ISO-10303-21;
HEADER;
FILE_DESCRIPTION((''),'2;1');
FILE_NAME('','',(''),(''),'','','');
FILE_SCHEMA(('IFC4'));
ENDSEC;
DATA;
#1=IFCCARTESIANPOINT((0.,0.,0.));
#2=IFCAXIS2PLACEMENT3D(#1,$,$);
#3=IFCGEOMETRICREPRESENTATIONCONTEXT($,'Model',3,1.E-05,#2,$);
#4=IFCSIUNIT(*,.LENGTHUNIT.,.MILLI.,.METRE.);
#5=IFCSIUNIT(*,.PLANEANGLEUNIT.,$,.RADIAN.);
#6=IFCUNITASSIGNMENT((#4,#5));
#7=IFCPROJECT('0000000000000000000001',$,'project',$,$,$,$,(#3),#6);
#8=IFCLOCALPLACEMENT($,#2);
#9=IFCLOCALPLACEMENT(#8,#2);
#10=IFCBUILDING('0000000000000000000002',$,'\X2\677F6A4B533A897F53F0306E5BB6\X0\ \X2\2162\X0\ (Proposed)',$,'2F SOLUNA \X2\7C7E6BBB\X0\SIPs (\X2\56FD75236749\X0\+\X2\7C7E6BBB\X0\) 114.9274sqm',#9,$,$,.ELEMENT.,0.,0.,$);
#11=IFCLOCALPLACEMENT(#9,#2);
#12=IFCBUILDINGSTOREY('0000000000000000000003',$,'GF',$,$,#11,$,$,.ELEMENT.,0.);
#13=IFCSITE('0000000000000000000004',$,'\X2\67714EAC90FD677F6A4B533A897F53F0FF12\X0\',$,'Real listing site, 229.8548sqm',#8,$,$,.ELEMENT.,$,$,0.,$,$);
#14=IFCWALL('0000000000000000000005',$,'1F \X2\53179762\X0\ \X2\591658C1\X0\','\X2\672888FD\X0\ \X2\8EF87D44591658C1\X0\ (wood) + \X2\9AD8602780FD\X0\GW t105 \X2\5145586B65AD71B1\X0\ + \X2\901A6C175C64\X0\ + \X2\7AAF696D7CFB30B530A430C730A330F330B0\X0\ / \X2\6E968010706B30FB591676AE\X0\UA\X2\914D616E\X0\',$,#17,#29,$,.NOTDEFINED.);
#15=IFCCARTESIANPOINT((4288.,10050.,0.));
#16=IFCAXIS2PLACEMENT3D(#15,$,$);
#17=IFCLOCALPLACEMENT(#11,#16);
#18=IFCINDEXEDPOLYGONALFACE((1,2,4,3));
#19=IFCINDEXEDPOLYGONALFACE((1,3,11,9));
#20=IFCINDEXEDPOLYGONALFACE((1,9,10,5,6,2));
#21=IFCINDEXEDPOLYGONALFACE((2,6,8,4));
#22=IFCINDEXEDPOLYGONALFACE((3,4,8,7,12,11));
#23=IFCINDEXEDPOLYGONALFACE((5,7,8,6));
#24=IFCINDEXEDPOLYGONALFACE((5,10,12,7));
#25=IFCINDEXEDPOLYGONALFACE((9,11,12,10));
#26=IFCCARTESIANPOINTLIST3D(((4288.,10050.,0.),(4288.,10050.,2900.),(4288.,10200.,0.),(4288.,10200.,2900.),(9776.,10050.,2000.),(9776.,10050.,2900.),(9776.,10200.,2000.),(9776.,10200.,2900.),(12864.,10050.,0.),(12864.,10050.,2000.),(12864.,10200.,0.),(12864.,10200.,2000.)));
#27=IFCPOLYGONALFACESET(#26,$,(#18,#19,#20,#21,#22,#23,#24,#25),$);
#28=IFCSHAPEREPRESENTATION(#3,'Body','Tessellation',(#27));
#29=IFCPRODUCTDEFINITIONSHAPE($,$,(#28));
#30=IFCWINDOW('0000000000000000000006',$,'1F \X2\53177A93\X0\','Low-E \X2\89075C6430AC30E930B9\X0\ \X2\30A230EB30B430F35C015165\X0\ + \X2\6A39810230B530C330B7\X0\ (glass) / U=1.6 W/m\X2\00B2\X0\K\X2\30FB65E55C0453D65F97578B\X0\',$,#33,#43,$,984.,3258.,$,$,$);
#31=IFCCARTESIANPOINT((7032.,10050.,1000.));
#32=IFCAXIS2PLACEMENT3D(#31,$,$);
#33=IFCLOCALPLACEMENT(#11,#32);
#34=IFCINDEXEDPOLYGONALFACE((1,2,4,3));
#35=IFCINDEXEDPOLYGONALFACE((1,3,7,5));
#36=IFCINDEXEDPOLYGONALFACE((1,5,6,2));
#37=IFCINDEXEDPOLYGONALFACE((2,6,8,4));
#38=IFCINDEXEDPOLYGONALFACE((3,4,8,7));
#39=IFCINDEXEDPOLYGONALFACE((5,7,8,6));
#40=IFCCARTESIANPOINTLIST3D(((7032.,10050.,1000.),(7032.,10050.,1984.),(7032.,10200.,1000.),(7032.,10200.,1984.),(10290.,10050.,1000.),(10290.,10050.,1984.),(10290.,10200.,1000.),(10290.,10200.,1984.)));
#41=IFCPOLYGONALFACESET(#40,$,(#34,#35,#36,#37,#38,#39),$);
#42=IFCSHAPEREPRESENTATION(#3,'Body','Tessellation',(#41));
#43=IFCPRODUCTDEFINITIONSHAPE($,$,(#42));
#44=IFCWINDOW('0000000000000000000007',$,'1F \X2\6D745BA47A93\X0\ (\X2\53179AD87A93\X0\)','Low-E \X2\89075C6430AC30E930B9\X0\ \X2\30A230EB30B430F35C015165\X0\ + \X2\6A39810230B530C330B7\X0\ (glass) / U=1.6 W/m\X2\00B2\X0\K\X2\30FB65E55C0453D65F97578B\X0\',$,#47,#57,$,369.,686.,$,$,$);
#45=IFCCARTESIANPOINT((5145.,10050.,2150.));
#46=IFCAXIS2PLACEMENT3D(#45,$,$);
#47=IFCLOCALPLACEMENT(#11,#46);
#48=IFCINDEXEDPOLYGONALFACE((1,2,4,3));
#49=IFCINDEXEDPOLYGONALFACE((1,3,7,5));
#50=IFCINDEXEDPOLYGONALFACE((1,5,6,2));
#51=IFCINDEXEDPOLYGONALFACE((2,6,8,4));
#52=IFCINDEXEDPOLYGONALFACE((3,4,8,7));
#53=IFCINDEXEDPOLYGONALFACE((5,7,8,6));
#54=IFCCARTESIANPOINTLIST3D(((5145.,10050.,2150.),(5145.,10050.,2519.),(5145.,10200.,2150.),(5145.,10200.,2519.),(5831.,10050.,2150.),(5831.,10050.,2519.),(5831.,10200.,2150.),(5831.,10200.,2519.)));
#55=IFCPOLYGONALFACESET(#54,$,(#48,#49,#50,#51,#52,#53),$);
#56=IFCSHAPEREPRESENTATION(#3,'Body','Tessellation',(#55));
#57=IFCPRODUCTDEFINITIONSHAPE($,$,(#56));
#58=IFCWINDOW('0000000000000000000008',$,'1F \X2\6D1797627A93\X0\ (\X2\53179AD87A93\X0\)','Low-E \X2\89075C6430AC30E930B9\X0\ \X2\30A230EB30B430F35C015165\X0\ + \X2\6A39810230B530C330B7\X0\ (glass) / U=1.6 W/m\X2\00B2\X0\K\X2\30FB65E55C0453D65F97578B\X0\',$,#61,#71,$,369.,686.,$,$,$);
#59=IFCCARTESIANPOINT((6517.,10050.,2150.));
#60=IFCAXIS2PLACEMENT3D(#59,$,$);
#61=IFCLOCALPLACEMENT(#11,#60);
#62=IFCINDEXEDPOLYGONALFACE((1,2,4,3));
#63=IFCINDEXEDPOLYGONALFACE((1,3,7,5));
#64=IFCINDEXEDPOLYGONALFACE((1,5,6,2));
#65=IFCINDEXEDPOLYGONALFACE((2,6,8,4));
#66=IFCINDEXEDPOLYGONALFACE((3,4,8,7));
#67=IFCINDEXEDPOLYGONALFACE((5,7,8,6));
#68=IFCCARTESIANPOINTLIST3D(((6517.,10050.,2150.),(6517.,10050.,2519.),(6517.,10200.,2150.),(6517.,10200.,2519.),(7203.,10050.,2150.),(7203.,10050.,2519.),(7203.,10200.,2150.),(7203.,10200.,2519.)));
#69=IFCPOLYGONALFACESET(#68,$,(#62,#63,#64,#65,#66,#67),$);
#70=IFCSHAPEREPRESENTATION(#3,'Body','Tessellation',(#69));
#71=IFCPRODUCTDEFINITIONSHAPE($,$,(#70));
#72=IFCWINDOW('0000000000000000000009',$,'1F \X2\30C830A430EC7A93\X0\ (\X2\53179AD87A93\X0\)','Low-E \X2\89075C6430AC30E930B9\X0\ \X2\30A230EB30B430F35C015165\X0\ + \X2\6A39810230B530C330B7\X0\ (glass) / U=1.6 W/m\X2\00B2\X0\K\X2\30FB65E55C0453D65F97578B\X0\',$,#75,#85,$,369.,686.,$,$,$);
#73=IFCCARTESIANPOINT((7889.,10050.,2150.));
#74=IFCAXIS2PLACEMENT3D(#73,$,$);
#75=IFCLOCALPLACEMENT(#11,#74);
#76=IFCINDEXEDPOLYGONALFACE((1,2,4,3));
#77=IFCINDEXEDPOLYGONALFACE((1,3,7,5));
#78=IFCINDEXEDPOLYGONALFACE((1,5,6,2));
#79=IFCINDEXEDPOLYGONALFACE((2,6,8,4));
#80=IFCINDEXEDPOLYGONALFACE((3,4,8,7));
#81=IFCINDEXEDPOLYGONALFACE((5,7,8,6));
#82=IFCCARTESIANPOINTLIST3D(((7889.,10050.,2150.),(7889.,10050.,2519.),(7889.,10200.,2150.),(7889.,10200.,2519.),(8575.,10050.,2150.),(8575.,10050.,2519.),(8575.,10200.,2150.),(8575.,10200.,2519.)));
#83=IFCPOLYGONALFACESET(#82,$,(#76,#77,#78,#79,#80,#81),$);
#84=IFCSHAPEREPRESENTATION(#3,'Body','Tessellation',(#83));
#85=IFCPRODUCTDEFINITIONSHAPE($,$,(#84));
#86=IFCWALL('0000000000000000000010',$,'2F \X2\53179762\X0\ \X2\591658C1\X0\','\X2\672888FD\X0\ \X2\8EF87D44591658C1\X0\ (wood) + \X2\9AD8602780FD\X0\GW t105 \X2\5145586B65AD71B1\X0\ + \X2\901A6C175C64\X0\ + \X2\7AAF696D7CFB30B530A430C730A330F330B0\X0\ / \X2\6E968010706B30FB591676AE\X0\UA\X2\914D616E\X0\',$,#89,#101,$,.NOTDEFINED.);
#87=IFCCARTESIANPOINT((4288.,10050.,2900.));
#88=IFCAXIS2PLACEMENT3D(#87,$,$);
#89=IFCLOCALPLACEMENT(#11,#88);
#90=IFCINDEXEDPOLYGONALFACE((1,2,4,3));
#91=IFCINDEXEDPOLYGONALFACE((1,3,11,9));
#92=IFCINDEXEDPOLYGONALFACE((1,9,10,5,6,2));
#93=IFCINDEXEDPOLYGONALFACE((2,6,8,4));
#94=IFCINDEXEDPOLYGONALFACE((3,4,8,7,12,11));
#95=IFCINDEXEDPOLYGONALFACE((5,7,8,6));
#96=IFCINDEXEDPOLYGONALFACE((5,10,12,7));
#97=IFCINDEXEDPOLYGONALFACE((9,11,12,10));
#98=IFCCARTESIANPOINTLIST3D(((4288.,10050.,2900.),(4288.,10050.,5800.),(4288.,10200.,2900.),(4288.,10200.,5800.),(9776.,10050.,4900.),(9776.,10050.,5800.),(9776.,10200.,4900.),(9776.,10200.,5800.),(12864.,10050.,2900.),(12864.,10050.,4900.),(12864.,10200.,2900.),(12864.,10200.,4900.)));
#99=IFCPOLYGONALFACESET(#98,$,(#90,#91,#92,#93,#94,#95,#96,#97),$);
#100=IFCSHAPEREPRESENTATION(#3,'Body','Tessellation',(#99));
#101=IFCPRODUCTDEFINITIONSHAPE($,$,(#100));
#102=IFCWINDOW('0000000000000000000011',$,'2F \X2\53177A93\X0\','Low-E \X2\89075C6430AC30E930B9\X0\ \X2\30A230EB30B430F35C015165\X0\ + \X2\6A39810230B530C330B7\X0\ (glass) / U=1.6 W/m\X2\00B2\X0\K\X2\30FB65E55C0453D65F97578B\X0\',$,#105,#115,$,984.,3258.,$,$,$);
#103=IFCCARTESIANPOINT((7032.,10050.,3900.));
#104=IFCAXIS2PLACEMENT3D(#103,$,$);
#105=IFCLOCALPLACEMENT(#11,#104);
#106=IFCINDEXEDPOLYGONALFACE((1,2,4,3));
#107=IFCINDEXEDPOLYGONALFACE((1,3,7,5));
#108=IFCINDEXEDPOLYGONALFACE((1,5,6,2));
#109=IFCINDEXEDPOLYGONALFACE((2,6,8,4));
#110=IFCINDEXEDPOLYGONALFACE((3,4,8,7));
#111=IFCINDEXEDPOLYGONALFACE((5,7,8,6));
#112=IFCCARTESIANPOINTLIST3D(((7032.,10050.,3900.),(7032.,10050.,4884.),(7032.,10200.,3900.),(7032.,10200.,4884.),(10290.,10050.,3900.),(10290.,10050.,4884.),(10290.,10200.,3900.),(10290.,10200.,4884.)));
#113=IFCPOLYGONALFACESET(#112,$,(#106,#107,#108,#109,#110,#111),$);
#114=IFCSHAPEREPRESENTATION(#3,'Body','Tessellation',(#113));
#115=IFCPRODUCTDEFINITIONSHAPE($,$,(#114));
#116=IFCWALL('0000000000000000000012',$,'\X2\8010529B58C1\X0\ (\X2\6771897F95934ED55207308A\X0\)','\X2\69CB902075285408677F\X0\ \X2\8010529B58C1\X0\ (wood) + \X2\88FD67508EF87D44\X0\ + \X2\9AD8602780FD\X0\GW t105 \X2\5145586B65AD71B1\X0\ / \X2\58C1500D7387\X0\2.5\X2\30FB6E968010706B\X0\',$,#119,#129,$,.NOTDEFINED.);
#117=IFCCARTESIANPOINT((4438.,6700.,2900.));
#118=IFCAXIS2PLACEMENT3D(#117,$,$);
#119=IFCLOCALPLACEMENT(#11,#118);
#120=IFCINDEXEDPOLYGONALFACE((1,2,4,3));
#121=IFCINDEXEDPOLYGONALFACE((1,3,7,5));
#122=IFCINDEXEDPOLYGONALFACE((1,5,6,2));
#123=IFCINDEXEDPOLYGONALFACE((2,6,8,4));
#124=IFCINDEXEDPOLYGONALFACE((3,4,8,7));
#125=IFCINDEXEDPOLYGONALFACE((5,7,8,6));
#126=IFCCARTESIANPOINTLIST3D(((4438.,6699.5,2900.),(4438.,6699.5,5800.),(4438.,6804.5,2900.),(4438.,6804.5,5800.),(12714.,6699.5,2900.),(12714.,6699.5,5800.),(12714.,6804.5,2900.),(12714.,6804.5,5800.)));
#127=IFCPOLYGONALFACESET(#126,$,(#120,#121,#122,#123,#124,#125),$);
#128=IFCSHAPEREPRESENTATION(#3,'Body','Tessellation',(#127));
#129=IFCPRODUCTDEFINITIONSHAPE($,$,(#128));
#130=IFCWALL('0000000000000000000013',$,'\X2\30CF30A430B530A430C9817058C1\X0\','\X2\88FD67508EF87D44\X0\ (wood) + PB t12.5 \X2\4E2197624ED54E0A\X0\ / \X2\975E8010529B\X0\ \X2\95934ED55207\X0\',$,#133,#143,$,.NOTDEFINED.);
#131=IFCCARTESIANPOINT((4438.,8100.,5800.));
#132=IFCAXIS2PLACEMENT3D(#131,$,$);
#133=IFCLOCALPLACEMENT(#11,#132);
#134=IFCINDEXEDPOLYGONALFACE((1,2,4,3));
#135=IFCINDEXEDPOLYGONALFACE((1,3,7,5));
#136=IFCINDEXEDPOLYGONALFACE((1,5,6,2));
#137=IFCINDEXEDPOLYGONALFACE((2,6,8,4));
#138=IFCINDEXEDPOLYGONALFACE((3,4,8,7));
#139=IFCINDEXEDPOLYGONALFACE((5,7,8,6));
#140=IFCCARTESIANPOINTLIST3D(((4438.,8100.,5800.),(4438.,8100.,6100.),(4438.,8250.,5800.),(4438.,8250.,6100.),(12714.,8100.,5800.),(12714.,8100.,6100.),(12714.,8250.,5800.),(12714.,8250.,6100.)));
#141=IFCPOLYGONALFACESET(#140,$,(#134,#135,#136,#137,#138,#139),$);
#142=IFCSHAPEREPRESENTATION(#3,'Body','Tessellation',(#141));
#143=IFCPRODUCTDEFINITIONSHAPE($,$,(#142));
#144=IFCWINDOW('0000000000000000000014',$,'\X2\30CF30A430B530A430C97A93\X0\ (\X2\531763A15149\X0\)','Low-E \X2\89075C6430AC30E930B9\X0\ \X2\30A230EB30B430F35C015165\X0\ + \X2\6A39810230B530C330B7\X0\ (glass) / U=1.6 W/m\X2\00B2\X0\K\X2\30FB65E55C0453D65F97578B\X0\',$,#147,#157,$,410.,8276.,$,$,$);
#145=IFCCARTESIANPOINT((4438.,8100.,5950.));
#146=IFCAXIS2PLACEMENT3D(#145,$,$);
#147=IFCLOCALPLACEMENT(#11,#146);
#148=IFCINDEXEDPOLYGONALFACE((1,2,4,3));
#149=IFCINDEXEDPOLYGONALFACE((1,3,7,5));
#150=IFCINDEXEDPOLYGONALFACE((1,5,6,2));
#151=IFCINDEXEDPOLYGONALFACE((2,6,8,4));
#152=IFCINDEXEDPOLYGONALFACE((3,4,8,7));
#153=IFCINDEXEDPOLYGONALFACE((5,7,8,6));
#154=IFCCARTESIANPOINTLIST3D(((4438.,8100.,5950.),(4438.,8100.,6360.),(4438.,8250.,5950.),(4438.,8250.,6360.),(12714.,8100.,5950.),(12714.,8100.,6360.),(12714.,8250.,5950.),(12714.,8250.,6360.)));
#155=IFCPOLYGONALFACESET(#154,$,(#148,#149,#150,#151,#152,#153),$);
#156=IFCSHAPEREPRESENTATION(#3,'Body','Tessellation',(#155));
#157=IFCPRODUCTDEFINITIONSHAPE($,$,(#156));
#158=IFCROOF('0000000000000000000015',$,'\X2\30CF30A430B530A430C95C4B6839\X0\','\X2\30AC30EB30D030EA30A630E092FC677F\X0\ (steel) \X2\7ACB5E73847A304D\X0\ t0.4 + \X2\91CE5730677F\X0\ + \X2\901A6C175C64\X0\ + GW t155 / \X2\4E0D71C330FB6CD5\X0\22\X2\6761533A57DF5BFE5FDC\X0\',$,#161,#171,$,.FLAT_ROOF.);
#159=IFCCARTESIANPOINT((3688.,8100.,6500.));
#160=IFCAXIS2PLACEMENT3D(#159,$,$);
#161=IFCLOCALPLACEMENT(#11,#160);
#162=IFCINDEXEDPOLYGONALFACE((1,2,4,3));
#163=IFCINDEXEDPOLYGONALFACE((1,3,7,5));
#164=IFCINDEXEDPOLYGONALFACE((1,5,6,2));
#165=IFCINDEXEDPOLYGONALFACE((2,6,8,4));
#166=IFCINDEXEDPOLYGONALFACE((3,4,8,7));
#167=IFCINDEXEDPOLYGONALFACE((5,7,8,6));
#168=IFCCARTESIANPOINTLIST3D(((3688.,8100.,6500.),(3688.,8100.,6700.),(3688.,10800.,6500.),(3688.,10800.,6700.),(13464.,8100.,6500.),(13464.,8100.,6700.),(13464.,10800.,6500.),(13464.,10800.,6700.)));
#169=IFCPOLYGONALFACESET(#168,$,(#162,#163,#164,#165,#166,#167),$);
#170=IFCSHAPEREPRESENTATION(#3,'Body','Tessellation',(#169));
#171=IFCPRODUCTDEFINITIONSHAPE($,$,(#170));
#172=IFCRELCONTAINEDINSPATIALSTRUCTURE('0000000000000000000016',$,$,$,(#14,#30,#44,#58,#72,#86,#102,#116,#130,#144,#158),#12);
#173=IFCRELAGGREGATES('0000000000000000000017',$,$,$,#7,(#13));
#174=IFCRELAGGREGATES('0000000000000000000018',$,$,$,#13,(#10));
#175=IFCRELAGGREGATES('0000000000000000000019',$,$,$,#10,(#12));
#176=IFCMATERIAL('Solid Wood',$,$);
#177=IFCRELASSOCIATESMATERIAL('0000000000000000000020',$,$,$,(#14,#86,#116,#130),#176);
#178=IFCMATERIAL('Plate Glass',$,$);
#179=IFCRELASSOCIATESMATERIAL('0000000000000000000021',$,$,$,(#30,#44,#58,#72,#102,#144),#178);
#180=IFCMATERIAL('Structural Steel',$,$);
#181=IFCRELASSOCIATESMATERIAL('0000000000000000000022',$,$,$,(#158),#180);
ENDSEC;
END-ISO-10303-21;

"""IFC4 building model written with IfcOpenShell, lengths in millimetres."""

from ifc_helpers import new_model, si_unit, frame, frame_2d, origin, place, context, project, spatial, rectangle, extrude, material, element, fill, save


model = new_model("IFC4")

# Units and contexts
model_context = context("Model", 3, precision=1e-05, world=origin())
ifc_project = project(units=[si_unit("LENGTHUNIT", "METRE", prefix="MILLI"), si_unit("PLANEANGLEUNIT", "RADIAN")], contexts=[model_context])

# Site, building, storey
site_placement = place(None, origin())
site = spatial("IfcSite", under=ifc_project, at=site_placement, Name="東京都板橋区西台２", ObjectType="Real listing site, 229.8548sqm", CompositionType="ELEMENT", RefElevation=0.0)
building_placement = place(site_placement, origin())
building = spatial("IfcBuilding", under=site, at=building_placement, Name="板橋区西台の家 Ⅲ (Proposed)", ObjectType="2F SOLUNA 籾殻SIPs (国産杉+籾殻) 114.9274sqm", CompositionType="ELEMENT", ElevationOfRefHeight=0.0, ElevationOfTerrain=0.0)
storey_placement = place(building_placement, origin())
storey = spatial("IfcBuildingStorey", under=building, at=storey_placement, Name="GF", CompositionType="ELEMENT", Elevation=0.0)

# Wall, openings, windows
ifc_material_1 = material(Name="Solid Wood")
wall_1_placement = place(storey_placement, frame((4288.0, 10050.0, 0.0)))
wall_1 = element("IfcWall", 1, at=wall_1_placement, inside=storey, material=ifc_material_1, Name="1F 北面 外壁", Description="木製 軸組外壁 (wood) + 高性能GW t105 充填断熱 + 通気層 + 窯業系サイディング / 準耐火・外皮UA配慮", PredefinedType="NOTDEFINED", context=model_context, shape_type="SweptSolid", body=[
    extrude(rectangle(XDim=8576.0, YDim=150.0, at=frame_2d((4288.0, 75.0))), frame((4288.0, 10050.0, 0.0)), (0.0, 0.0, 1.0), 2900.0),
])
opening_1_placement = place(storey_placement, frame((7032.0, 10050.0, 1000.0)))
opening_1 = element("IfcOpeningElement", 2, at=opening_1_placement, cuts=wall_1, PredefinedType="NOTDEFINED", context=model_context, shape_type="SweptSolid", body=[
    extrude(rectangle(XDim=3258.0, YDim=150.0, at=frame_2d((1629.0, 75.0))), frame((7032.0, 10050.0, 1000.0)), (0.0, 0.0, 1.0), 984.0),
])
opening_2_placement = place(storey_placement, frame((5145.0, 10050.0, 2150.0)))
opening_2 = element("IfcOpeningElement", 3, at=opening_2_placement, cuts=wall_1, PredefinedType="NOTDEFINED", context=model_context, shape_type="SweptSolid", body=[
    extrude(rectangle(XDim=686.0, YDim=150.0, at=frame_2d((343.0, 75.0))), frame((5145.0, 10050.0, 2150.0)), (0.0, 0.0, 1.0), 369.0),
])
opening_3_placement = place(storey_placement, frame((6517.0, 10050.0, 2150.0)))
opening_3 = element("IfcOpeningElement", 4, at=opening_3_placement, cuts=wall_1, PredefinedType="NOTDEFINED", context=model_context, shape_type="SweptSolid", body=[
    extrude(rectangle(XDim=686.0, YDim=150.0, at=frame_2d((343.0, 75.0))), frame((6517.0, 10050.0, 2150.0)), (0.0, 0.0, 1.0), 369.0),
])
opening_4_placement = place(storey_placement, frame((7889.0, 10050.0, 2150.0)))
opening_4 = element("IfcOpeningElement", 5, at=opening_4_placement, cuts=wall_1, PredefinedType="NOTDEFINED", context=model_context, shape_type="SweptSolid", body=[
    extrude(rectangle(XDim=686.0, YDim=150.0, at=frame_2d((343.0, 75.0))), frame((7889.0, 10050.0, 2150.0)), (0.0, 0.0, 1.0), 369.0),
])
ifc_material_2 = material(Name="Plate Glass")
window_1_placement = place(storey_placement, frame((7032.0, 10050.0, 1000.0)))
window_1 = element("IfcWindow", 6, at=window_1_placement, inside=storey, material=ifc_material_2, Name="1F 北窓", Description="Low-E 複層ガラス アルゴン封入 + 樹脂サッシ (glass) / U=1.6 W/m²K・日射取得型", OverallHeight=984.0, OverallWidth=3258.0, context=model_context, shape_type="SweptSolid", body=[
    extrude(rectangle(XDim=3258.0, YDim=150.0, at=frame_2d((1629.0, 75.0))), frame((7032.0, 10050.0, 1000.0)), (0.0, 0.0, 1.0), 984.0),
])
fill(opening_1, window_1)
window_2_placement = place(storey_placement, frame((5145.0, 10050.0, 2150.0)))
window_2 = element("IfcWindow", 7, at=window_2_placement, inside=storey, material=ifc_material_2, Name="1F 浴室窓 (北高窓)", Description="Low-E 複層ガラス アルゴン封入 + 樹脂サッシ (glass) / U=1.6 W/m²K・日射取得型", OverallHeight=369.0, OverallWidth=686.0, context=model_context, shape_type="SweptSolid", body=[
    extrude(rectangle(XDim=686.0, YDim=150.0, at=frame_2d((343.0, 75.0))), frame((5145.0, 10050.0, 2150.0)), (0.0, 0.0, 1.0), 369.0),
])
fill(opening_2, window_2)
window_3_placement = place(storey_placement, frame((6517.0, 10050.0, 2150.0)))
window_3 = element("IfcWindow", 8, at=window_3_placement, inside=storey, material=ifc_material_2, Name="1F 洗面窓 (北高窓)", Description="Low-E 複層ガラス アルゴン封入 + 樹脂サッシ (glass) / U=1.6 W/m²K・日射取得型", OverallHeight=369.0, OverallWidth=686.0, context=model_context, shape_type="SweptSolid", body=[
    extrude(rectangle(XDim=686.0, YDim=150.0, at=frame_2d((343.0, 75.0))), frame((6517.0, 10050.0, 2150.0)), (0.0, 0.0, 1.0), 369.0),
])
fill(opening_3, window_3)
window_4_placement = place(storey_placement, frame((7889.0, 10050.0, 2150.0)))
window_4 = element("IfcWindow", 9, at=window_4_placement, inside=storey, material=ifc_material_2, Name="1F トイレ窓 (北高窓)", Description="Low-E 複層ガラス アルゴン封入 + 樹脂サッシ (glass) / U=1.6 W/m²K・日射取得型", OverallHeight=369.0, OverallWidth=686.0, context=model_context, shape_type="SweptSolid", body=[
    extrude(rectangle(XDim=686.0, YDim=150.0, at=frame_2d((343.0, 75.0))), frame((7889.0, 10050.0, 2150.0)), (0.0, 0.0, 1.0), 369.0),
])
fill(opening_4, window_4)

# Wall, opening, window
wall_2_placement = place(storey_placement, frame((4288.0, 10050.0, 2900.0)))
wall_2 = element("IfcWall", 10, at=wall_2_placement, inside=storey, material=ifc_material_1, Name="2F 北面 外壁", Description="木製 軸組外壁 (wood) + 高性能GW t105 充填断熱 + 通気層 + 窯業系サイディング / 準耐火・外皮UA配慮", PredefinedType="NOTDEFINED", context=model_context, shape_type="SweptSolid", body=[
    extrude(rectangle(XDim=8576.0, YDim=150.0, at=frame_2d((4288.0, 75.0))), frame((4288.0, 10050.0, 2900.0)), (0.0, 0.0, 1.0), 2900.0),
])
opening_5_placement = place(storey_placement, frame((7032.0, 10050.0, 3900.0)))
opening_5 = element("IfcOpeningElement", 11, at=opening_5_placement, cuts=wall_2, PredefinedType="NOTDEFINED", context=model_context, shape_type="SweptSolid", body=[
    extrude(rectangle(XDim=3258.0, YDim=150.0, at=frame_2d((1629.0, 75.0))), frame((7032.0, 10050.0, 3900.0)), (0.0, 0.0, 1.0), 984.0),
])
window_5_placement = place(storey_placement, frame((7032.0, 10050.0, 3900.0)))
window_5 = element("IfcWindow", 12, at=window_5_placement, inside=storey, material=ifc_material_2, Name="2F 北窓", Description="Low-E 複層ガラス アルゴン封入 + 樹脂サッシ (glass) / U=1.6 W/m²K・日射取得型", OverallHeight=984.0, OverallWidth=3258.0, context=model_context, shape_type="SweptSolid", body=[
    extrude(rectangle(XDim=3258.0, YDim=150.0, at=frame_2d((1629.0, 75.0))), frame((7032.0, 10050.0, 3900.0)), (0.0, 0.0, 1.0), 984.0),
])
fill(opening_5, window_5)

# Wall
wall_3_placement = place(storey_placement, frame((4438.0, 6700.0, 2900.0)))
element("IfcWall", 13, at=wall_3_placement, inside=storey, material=ifc_material_1, Name="耐力壁 (東西間仕切り)", Description="構造用合板 耐力壁 (wood) + 製材軸組 + 高性能GW t105 充填断熱 / 壁倍率2.5・準耐火", PredefinedType="NOTDEFINED", context=model_context, shape_type="SweptSolid", body=[
    extrude(rectangle(XDim=8276.0, YDim=105.0, at=frame_2d((4138.0, 52.0))), frame((4438.0, 6700.0, 2900.0)), (0.0, 0.0, 1.0), 2900.0),
])

# Wall, opening, window
wall_4_placement = place(storey_placement, frame((4438.0, 8100.0, 5800.0)))
wall_4 = element("IfcWall", 14, at=wall_4_placement, inside=storey, material=ifc_material_1, Name="ハイサイド腰壁", Description="製材軸組 (wood) + PB t12.5 両面仕上 / 非耐力 間仕切", PredefinedType="NOTDEFINED", context=model_context, shape_type="SweptSolid", body=[
    extrude(rectangle(XDim=8276.0, YDim=150.0, at=frame_2d((4138.0, 75.0))), frame((4438.0, 8100.0, 5800.0)), (0.0, 0.0, 1.0), 700.0),
])
opening_6_placement = place(storey_placement, frame((4438.0, 8100.0, 5950.0)))
opening_6 = element("IfcOpeningElement", 15, at=opening_6_placement, cuts=wall_4, PredefinedType="NOTDEFINED", context=model_context, shape_type="SweptSolid", body=[
    extrude(rectangle(XDim=8276.0, YDim=150.0, at=frame_2d((4138.0, 75.0))), frame((4438.0, 8100.0, 5950.0)), (0.0, 0.0, 1.0), 410.0),
])
window_6_placement = place(storey_placement, frame((4438.0, 8100.0, 5950.0)))
window_6 = element("IfcWindow", 16, at=window_6_placement, inside=storey, material=ifc_material_2, Name="ハイサイド窓 (北採光)", Description="Low-E 複層ガラス アルゴン封入 + 樹脂サッシ (glass) / U=1.6 W/m²K・日射取得型", OverallHeight=410.0, OverallWidth=8276.0, context=model_context, shape_type="SweptSolid", body=[
    extrude(rectangle(XDim=8276.0, YDim=150.0, at=frame_2d((4138.0, 75.0))), frame((4438.0, 8100.0, 5950.0)), (0.0, 0.0, 1.0), 410.0),
])
fill(opening_6, window_6)

# Roof
ifc_material_3 = material(Name="Structural Steel")
roof_placement = place(storey_placement, frame((3688.0, 8100.0, 6500.0)))
element("IfcRoof", 17, at=roof_placement, inside=storey, material=ifc_material_3, Name="ハイサイド屋根", Description="ガルバリウム鋼板 (steel) 立平葺き t0.4 + 野地板 + 通気層 + GW t155 / 不燃・法22条区域対応", PredefinedType="FLAT_ROOF", context=model_context, shape_type="SweptSolid", body=[
    extrude(rectangle(XDim=9776.0, YDim=2700.0, at=frame_2d((4888.0, 1350.0))), frame((3688.0, 8100.0, 6500.0)), (0.0, 0.0, 1.0), 200.0),
])

save(model, "model.ifc")
